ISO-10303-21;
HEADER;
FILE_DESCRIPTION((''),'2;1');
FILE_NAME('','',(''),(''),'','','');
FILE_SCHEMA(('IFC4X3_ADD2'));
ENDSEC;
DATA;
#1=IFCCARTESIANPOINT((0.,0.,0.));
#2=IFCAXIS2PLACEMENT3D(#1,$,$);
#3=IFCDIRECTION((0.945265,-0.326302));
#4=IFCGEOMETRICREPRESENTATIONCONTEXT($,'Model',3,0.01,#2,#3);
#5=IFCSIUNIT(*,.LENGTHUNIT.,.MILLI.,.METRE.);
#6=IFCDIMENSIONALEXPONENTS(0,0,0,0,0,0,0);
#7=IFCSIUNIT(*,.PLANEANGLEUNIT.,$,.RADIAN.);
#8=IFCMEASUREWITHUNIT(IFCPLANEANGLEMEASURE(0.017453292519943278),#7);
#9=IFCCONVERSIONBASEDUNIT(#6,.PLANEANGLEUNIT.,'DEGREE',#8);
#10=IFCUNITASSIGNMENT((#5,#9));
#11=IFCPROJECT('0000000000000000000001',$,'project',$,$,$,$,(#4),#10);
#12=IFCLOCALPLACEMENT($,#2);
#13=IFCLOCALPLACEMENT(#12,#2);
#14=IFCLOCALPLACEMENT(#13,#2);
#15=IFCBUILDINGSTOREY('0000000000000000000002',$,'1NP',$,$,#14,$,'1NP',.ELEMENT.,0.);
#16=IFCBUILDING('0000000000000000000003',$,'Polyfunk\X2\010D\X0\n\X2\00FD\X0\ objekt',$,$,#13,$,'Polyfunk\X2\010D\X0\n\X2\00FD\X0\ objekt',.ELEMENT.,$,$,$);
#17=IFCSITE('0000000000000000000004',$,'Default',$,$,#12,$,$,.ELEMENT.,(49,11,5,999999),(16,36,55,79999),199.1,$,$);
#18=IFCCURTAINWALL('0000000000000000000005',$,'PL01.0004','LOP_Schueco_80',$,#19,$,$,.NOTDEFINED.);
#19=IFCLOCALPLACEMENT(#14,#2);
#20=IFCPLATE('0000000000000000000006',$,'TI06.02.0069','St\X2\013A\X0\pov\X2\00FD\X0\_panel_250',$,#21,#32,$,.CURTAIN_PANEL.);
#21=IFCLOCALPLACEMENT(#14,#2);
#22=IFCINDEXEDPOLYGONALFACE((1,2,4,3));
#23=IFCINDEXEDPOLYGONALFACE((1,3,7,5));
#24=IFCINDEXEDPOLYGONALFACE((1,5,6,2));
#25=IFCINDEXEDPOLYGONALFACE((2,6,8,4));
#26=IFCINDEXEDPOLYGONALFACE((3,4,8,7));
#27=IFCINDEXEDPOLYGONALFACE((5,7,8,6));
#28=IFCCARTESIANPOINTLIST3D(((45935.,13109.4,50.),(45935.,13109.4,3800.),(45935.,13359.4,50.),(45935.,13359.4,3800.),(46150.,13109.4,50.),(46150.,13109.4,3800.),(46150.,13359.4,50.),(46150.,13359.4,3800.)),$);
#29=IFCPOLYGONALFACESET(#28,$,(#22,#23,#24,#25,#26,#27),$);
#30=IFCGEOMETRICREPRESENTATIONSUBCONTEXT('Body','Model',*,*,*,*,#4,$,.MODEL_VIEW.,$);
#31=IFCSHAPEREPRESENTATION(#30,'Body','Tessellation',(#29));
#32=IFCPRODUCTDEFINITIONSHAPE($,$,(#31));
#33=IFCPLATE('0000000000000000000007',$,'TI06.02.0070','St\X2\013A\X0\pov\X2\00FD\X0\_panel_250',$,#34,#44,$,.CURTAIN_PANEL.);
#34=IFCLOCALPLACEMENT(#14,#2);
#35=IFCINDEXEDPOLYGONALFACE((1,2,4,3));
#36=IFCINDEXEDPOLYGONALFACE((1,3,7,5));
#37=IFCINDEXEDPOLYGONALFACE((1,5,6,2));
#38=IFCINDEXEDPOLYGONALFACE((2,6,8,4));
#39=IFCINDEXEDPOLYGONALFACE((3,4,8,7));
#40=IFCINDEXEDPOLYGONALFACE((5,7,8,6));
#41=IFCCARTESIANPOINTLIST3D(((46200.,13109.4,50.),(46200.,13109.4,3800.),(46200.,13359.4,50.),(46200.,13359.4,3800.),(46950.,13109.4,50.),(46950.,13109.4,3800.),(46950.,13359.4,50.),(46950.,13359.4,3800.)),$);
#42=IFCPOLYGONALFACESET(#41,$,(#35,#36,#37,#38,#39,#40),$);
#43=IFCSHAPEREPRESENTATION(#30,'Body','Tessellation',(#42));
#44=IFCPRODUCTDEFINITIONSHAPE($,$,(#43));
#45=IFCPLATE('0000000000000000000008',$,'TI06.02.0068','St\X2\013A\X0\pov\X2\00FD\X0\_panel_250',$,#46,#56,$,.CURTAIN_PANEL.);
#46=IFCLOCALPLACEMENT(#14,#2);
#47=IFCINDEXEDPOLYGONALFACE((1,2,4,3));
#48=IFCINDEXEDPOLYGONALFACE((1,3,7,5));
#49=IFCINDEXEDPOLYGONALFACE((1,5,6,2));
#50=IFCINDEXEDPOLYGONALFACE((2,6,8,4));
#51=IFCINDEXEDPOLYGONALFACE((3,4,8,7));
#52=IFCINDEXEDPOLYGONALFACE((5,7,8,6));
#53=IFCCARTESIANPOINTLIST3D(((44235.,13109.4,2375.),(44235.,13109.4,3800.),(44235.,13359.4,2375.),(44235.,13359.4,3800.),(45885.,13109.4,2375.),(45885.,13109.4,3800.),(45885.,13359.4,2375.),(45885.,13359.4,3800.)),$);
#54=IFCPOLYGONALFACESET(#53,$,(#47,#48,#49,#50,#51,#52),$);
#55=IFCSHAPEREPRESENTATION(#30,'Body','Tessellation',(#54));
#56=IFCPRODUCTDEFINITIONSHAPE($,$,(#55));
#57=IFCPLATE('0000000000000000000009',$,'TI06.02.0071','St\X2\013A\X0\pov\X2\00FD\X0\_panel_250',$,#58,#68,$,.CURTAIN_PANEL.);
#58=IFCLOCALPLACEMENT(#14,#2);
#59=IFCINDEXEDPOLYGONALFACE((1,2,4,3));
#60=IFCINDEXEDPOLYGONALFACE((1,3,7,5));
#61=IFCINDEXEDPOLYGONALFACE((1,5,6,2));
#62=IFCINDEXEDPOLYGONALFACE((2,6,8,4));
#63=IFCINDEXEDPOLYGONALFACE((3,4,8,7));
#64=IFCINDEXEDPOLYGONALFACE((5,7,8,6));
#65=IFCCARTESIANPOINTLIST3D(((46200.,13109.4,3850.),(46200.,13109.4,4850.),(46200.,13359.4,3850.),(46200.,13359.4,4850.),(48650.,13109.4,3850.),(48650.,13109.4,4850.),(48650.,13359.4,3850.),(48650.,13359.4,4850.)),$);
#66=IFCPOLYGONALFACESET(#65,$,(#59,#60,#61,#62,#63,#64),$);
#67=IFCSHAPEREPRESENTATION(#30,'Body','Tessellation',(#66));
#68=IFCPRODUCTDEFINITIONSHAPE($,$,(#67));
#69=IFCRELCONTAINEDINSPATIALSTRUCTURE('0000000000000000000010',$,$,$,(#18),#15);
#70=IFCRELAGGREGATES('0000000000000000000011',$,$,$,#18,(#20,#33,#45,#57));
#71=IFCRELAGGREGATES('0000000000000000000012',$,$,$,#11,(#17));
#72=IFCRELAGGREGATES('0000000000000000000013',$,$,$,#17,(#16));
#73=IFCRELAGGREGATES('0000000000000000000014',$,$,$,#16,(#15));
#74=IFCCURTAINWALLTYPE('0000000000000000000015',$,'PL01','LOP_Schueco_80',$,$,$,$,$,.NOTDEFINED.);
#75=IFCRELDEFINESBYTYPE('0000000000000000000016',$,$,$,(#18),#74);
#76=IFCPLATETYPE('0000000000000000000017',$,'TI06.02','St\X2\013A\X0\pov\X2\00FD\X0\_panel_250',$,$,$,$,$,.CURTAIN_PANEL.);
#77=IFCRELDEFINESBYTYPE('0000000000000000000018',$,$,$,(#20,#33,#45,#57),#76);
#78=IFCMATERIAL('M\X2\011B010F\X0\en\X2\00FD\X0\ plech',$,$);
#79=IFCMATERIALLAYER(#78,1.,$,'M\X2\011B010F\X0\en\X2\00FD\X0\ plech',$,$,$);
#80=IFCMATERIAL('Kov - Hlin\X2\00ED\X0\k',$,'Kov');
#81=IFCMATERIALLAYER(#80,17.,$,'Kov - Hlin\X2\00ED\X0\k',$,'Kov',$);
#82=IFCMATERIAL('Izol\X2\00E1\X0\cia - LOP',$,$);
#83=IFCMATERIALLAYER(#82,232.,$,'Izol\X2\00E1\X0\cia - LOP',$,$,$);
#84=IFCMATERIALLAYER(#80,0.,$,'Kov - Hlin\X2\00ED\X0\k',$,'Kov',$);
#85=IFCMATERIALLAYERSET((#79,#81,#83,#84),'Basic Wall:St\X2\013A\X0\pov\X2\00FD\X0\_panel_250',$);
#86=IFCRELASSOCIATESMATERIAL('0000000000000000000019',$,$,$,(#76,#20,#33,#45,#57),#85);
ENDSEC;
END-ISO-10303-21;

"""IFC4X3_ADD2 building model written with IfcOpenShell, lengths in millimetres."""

from ifc_helpers import new_model, entity, si_unit, converted_unit, direction, frame, frame_2d, origin, place, context, subcontext, project, spatial, rectangle, extrude, material, layer, layer_set, layer_usage, type_object, element, aggregate, save


model = new_model("IFC4X3_ADD2")

# Units and contexts
model_context = context("Model", 3, precision=0.01, world=origin(), true_north=direction((0.945265, -0.326302)))
body_context = subcontext(model_context, "Body", "Model", "MODEL_VIEW")
ifc_project = project(units=[si_unit("LENGTHUNIT", "METRE", prefix="MILLI"), converted_unit("PLANEANGLEUNIT", "DEGREE", entity("IfcPlaneAngleMeasure", 0.017453292519943278), si_unit("PLANEANGLEUNIT", "RADIAN"), dimensions=[0, 0, 0, 0, 0, 0, 0])], contexts=[model_context])

# Site, building, storey
site_placement = place(None, origin())
site = spatial("IfcSite", under=ifc_project, at=site_placement, Name="Default", CompositionType="ELEMENT", RefLatitude=(49, 11, 5, 999999), RefLongitude=(16, 36, 55, 79999), RefElevation=199.1)
building_placement = place(site_placement, origin())
building = spatial("IfcBuilding", under=site, at=building_placement, Name="Polyfunkčný objekt", LongName="Polyfunkčný objekt", CompositionType="ELEMENT")
storey_placement = place(building_placement, origin())
storey = spatial("IfcBuildingStorey", under=building, at=storey_placement, Name="1NP", LongName="1NP", CompositionType="ELEMENT", Elevation=0.0)

# Curtain wall, plates
curtain_wall_type = type_object("IfcCurtainWallType", Name="PL01", Description="LOP_Schueco_80", PredefinedType="NOTDEFINED")
curtain_wall_placement = place(storey_placement, origin())
curtain_wall = element("IfcCurtainWall", 1, at=curtain_wall_placement, inside=storey, type_object=curtain_wall_type, Name="PL01.0004", Description="LOP_Schueco_80", PredefinedType="NOTDEFINED")
ifc_material_1 = material(Name="Měďený plech")
ifc_layer_1 = layer(ifc_material_1, 1.0, Name="Měďený plech")
ifc_material_2 = material(Name="Kov - Hliník", Category="Kov")
ifc_layer_2 = layer(ifc_material_2, 17.0, Name="Kov - Hliník", Category="Kov")
ifc_material_3 = material(Name="Izolácia - LOP")
ifc_layer_3 = layer(ifc_material_3, 232.0, Name="Izolácia - LOP")
ifc_layer_4 = layer(ifc_material_2, 0.0, Name="Kov - Hliník", Category="Kov")
ifc_layer_set = layer_set([ifc_layer_1, ifc_layer_2, ifc_layer_3, ifc_layer_4], Name="Basic Wall:Stĺpový_panel_250")
ifc_layer_usage_1 = layer_usage(ifc_layer_set, "AXIS2", "NEGATIVE", 125.0)
plate_type = type_object("IfcPlateType", Name="TI06.02", Description="Stĺpový_panel_250", PredefinedType="CURTAIN_PANEL", material=ifc_layer_set)
plate_1_placement = place(storey_placement, frame((45935.0, 13234.4, 50.0)))
plate_1 = element("IfcPlate", 2, at=plate_1_placement, type_object=plate_type, material=ifc_layer_usage_1, Name="TI06.02.0069", Description="Stĺpový_panel_250", PredefinedType="CURTAIN_PANEL", context=body_context, shape_type="SweptSolid", body=[
    extrude(rectangle(XDim=250.0, YDim=215.0, at=frame_2d((0.0, 0.0), x_axis=(1.0, 0.0))), frame((107.5, 0.0, 0.0), z_axis=(0.0, 0.0, 1.0), x_axis=(0.0, 1.0, 0.0)), (0.0, 0.0, 1.0), 3750.0),
])
ifc_layer_usage_2 = layer_usage(ifc_layer_set, "AXIS2", "NEGATIVE", 125.0)
plate_2_placement = place(storey_placement, frame((46200.0, 13234.4, 50.0)))
plate_2 = element("IfcPlate", 3, at=plate_2_placement, type_object=plate_type, material=ifc_layer_usage_2, Name="TI06.02.0070", Description="Stĺpový_panel_250", PredefinedType="CURTAIN_PANEL", context=body_context, shape_type="SweptSolid", body=[
    extrude(rectangle(XDim=250.0, YDim=750.0, at=frame_2d((0.0, 0.0), x_axis=(1.0, 0.0))), frame((375.0, 0.0, 0.0), z_axis=(0.0, 0.0, 1.0), x_axis=(0.0, 1.0, 0.0)), (0.0, 0.0, 1.0), 3750.0),
])
ifc_layer_usage_3 = layer_usage(ifc_layer_set, "AXIS2", "NEGATIVE", 125.0)
plate_3_placement = place(storey_placement, frame((44235.0, 13234.4, 2375.0)))
plate_3 = element("IfcPlate", 4, at=plate_3_placement, type_object=plate_type, material=ifc_layer_usage_3, Name="TI06.02.0068", Description="Stĺpový_panel_250", PredefinedType="CURTAIN_PANEL", context=body_context, shape_type="SweptSolid", body=[
    extrude(rectangle(XDim=250.0, YDim=1650.0, at=frame_2d((0.0, 0.0), x_axis=(1.0, 0.0))), frame((825.0, 0.0, 0.0), z_axis=(0.0, 0.0, 1.0), x_axis=(0.0, 1.0, 0.0)), (0.0, 0.0, 1.0), 1425.0),
])
ifc_layer_usage_4 = layer_usage(ifc_layer_set, "AXIS2", "NEGATIVE", 125.0)
plate_4_placement = place(storey_placement, frame((46200.0, 13234.4, 3850.0)))
plate_4 = element("IfcPlate", 5, at=plate_4_placement, type_object=plate_type, material=ifc_layer_usage_4, Name="TI06.02.0071", Description="Stĺpový_panel_250", PredefinedType="CURTAIN_PANEL", context=body_context, shape_type="SweptSolid", body=[
    extrude(rectangle(XDim=250.0, YDim=2450.0, at=frame_2d((0.0, 0.0), x_axis=(1.0, 0.0))), frame((1225.0, 0.0, 0.0), z_axis=(0.0, 0.0, 1.0), x_axis=(0.0, 1.0, 0.0)), (0.0, 0.0, 1.0), 1000.0),
])
aggregate(curtain_wall, [plate_1, plate_2, plate_3, plate_4])

save(model, "model.ifc")
